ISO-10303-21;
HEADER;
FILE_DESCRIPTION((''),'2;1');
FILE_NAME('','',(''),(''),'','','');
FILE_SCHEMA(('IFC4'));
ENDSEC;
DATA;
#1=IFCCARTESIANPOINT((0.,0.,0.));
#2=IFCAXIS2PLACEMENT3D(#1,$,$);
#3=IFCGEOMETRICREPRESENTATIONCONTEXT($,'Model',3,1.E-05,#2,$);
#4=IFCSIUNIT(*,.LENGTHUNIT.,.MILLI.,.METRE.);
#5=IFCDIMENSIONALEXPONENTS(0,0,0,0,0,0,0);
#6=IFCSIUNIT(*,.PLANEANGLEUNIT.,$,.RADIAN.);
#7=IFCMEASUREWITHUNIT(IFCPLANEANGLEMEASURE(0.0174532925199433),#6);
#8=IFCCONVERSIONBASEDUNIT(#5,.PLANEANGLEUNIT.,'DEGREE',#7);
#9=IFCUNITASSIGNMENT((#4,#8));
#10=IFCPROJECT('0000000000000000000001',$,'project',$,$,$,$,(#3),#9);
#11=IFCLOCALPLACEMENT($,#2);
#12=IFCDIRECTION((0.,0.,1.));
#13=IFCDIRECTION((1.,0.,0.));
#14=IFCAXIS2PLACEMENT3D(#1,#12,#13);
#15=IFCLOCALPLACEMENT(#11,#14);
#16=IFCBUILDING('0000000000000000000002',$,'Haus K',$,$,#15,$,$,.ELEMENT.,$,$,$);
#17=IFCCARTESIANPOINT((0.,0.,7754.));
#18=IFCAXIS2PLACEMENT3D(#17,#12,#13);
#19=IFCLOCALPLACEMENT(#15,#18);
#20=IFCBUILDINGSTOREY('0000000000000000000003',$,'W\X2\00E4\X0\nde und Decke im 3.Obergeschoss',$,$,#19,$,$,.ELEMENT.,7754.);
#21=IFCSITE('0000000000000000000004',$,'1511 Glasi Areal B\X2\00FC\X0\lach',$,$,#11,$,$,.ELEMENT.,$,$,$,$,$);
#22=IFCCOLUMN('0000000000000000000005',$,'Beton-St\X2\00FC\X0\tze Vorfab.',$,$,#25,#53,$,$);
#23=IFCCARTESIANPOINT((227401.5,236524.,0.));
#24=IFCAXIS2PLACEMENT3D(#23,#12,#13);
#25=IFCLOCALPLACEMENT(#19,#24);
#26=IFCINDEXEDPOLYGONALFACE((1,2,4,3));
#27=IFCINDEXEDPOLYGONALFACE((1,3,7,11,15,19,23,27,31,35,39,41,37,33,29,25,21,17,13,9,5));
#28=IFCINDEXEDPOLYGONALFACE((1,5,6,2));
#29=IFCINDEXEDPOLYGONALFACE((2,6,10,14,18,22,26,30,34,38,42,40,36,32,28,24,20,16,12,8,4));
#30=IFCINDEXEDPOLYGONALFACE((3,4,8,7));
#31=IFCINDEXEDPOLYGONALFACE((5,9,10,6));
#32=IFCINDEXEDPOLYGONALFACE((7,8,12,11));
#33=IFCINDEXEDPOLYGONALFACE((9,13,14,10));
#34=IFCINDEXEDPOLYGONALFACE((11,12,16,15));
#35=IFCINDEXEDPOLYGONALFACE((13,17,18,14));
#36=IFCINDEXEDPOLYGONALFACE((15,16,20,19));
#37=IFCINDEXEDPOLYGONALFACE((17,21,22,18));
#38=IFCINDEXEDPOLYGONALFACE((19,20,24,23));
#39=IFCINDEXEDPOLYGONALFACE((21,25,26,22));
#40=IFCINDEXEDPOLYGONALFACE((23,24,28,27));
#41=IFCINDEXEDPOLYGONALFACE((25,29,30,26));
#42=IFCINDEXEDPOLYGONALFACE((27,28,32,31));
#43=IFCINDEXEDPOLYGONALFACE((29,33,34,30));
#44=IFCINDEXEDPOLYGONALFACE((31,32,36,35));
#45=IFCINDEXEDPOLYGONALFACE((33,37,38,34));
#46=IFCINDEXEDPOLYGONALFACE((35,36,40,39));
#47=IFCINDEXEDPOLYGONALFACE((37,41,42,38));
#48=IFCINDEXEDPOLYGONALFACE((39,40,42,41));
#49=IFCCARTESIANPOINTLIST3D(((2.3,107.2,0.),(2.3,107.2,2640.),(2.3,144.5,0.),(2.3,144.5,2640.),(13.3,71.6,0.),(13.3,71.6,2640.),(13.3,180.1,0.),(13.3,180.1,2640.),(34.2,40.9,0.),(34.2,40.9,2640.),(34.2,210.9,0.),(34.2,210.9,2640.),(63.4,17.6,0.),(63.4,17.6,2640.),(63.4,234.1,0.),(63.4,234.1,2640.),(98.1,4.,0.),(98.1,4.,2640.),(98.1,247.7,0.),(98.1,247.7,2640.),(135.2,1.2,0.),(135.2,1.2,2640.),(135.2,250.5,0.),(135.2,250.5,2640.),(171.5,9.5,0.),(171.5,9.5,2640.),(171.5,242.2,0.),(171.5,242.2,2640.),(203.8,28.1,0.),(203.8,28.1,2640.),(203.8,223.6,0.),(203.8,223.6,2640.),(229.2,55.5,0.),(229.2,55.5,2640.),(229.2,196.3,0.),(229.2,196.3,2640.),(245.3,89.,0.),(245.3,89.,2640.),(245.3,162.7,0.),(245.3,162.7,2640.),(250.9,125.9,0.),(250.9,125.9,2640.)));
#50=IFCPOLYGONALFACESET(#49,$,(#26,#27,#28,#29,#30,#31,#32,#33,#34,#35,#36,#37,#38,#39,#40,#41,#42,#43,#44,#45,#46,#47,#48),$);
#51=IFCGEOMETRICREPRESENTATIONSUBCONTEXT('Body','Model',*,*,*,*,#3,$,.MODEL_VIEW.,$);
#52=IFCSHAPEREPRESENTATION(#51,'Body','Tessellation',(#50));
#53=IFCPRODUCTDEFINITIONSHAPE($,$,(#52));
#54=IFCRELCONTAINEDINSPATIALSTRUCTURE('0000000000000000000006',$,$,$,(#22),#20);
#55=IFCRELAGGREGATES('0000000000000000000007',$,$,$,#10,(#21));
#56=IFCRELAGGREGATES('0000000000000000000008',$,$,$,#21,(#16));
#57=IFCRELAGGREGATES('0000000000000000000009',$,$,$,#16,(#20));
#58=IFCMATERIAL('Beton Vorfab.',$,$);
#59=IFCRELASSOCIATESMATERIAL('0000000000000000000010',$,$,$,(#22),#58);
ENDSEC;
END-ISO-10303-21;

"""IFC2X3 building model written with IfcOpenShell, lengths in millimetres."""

from ifc_helpers import new_model, entity, si_unit, converted_unit, frame, frame_2d, origin, origin_with_axes, place, context, subcontext, project, spatial, circle, extrude, material, element, save


model = new_model("IFC2X3")

# Units and contexts
model_context = context("Model", 3, precision=1e-05, world=origin())
body_context = subcontext(model_context, "Body", "Model", "MODEL_VIEW")
ifc_project = project(units=[si_unit("LENGTHUNIT", "METRE", prefix="MILLI"), converted_unit("PLANEANGLEUNIT", "DEGREE", entity("IfcPlaneAngleMeasure", 0.0174532925199433), si_unit("PLANEANGLEUNIT", "RADIAN"), dimensions=[0, 0, 0, 0, 0, 0, 0])], contexts=[model_context])

# Site, building, storey
site_placement = place(None, origin())
site = spatial("IfcSite", under=ifc_project, at=site_placement, Name="1511 Glasi Areal Bülach", CompositionType="ELEMENT")
building_placement = place(site_placement, origin_with_axes())
building = spatial("IfcBuilding", under=site, at=building_placement, Name="Haus K", CompositionType="ELEMENT")
storey_placement = place(building_placement, frame((0.0, 0.0, 7754.0), z_axis=(0.0, 0.0, 1.0), x_axis=(1.0, 0.0, 0.0)))
storey = spatial("IfcBuildingStorey", under=building, at=storey_placement, Name="Wände und Decke im 3.Obergeschoss", CompositionType="ELEMENT", Elevation=7754.0)

# Column
ifc_material_1 = material(Name="Beton Vorfab.")
column_placement = place(storey_placement, frame((227401.5, 236524.0, 0.0), z_axis=(0.0, 0.0, 1.0), x_axis=(1.0, 0.0, 0.0)))
element("IfcColumn", 1, at=column_placement, inside=storey, material=ifc_material_1, Name="Beton-Stütze Vorfab.", context=body_context, shape_type="SweptSolid", body=[
    extrude(circle(Radius=125.0, at=frame_2d((125.9, 125.9), x_axis=(1.0, 0.0))), origin_with_axes(), (0.0, 0.0, 1.0), 2640.0),
])

save(model, "model.ifc")
